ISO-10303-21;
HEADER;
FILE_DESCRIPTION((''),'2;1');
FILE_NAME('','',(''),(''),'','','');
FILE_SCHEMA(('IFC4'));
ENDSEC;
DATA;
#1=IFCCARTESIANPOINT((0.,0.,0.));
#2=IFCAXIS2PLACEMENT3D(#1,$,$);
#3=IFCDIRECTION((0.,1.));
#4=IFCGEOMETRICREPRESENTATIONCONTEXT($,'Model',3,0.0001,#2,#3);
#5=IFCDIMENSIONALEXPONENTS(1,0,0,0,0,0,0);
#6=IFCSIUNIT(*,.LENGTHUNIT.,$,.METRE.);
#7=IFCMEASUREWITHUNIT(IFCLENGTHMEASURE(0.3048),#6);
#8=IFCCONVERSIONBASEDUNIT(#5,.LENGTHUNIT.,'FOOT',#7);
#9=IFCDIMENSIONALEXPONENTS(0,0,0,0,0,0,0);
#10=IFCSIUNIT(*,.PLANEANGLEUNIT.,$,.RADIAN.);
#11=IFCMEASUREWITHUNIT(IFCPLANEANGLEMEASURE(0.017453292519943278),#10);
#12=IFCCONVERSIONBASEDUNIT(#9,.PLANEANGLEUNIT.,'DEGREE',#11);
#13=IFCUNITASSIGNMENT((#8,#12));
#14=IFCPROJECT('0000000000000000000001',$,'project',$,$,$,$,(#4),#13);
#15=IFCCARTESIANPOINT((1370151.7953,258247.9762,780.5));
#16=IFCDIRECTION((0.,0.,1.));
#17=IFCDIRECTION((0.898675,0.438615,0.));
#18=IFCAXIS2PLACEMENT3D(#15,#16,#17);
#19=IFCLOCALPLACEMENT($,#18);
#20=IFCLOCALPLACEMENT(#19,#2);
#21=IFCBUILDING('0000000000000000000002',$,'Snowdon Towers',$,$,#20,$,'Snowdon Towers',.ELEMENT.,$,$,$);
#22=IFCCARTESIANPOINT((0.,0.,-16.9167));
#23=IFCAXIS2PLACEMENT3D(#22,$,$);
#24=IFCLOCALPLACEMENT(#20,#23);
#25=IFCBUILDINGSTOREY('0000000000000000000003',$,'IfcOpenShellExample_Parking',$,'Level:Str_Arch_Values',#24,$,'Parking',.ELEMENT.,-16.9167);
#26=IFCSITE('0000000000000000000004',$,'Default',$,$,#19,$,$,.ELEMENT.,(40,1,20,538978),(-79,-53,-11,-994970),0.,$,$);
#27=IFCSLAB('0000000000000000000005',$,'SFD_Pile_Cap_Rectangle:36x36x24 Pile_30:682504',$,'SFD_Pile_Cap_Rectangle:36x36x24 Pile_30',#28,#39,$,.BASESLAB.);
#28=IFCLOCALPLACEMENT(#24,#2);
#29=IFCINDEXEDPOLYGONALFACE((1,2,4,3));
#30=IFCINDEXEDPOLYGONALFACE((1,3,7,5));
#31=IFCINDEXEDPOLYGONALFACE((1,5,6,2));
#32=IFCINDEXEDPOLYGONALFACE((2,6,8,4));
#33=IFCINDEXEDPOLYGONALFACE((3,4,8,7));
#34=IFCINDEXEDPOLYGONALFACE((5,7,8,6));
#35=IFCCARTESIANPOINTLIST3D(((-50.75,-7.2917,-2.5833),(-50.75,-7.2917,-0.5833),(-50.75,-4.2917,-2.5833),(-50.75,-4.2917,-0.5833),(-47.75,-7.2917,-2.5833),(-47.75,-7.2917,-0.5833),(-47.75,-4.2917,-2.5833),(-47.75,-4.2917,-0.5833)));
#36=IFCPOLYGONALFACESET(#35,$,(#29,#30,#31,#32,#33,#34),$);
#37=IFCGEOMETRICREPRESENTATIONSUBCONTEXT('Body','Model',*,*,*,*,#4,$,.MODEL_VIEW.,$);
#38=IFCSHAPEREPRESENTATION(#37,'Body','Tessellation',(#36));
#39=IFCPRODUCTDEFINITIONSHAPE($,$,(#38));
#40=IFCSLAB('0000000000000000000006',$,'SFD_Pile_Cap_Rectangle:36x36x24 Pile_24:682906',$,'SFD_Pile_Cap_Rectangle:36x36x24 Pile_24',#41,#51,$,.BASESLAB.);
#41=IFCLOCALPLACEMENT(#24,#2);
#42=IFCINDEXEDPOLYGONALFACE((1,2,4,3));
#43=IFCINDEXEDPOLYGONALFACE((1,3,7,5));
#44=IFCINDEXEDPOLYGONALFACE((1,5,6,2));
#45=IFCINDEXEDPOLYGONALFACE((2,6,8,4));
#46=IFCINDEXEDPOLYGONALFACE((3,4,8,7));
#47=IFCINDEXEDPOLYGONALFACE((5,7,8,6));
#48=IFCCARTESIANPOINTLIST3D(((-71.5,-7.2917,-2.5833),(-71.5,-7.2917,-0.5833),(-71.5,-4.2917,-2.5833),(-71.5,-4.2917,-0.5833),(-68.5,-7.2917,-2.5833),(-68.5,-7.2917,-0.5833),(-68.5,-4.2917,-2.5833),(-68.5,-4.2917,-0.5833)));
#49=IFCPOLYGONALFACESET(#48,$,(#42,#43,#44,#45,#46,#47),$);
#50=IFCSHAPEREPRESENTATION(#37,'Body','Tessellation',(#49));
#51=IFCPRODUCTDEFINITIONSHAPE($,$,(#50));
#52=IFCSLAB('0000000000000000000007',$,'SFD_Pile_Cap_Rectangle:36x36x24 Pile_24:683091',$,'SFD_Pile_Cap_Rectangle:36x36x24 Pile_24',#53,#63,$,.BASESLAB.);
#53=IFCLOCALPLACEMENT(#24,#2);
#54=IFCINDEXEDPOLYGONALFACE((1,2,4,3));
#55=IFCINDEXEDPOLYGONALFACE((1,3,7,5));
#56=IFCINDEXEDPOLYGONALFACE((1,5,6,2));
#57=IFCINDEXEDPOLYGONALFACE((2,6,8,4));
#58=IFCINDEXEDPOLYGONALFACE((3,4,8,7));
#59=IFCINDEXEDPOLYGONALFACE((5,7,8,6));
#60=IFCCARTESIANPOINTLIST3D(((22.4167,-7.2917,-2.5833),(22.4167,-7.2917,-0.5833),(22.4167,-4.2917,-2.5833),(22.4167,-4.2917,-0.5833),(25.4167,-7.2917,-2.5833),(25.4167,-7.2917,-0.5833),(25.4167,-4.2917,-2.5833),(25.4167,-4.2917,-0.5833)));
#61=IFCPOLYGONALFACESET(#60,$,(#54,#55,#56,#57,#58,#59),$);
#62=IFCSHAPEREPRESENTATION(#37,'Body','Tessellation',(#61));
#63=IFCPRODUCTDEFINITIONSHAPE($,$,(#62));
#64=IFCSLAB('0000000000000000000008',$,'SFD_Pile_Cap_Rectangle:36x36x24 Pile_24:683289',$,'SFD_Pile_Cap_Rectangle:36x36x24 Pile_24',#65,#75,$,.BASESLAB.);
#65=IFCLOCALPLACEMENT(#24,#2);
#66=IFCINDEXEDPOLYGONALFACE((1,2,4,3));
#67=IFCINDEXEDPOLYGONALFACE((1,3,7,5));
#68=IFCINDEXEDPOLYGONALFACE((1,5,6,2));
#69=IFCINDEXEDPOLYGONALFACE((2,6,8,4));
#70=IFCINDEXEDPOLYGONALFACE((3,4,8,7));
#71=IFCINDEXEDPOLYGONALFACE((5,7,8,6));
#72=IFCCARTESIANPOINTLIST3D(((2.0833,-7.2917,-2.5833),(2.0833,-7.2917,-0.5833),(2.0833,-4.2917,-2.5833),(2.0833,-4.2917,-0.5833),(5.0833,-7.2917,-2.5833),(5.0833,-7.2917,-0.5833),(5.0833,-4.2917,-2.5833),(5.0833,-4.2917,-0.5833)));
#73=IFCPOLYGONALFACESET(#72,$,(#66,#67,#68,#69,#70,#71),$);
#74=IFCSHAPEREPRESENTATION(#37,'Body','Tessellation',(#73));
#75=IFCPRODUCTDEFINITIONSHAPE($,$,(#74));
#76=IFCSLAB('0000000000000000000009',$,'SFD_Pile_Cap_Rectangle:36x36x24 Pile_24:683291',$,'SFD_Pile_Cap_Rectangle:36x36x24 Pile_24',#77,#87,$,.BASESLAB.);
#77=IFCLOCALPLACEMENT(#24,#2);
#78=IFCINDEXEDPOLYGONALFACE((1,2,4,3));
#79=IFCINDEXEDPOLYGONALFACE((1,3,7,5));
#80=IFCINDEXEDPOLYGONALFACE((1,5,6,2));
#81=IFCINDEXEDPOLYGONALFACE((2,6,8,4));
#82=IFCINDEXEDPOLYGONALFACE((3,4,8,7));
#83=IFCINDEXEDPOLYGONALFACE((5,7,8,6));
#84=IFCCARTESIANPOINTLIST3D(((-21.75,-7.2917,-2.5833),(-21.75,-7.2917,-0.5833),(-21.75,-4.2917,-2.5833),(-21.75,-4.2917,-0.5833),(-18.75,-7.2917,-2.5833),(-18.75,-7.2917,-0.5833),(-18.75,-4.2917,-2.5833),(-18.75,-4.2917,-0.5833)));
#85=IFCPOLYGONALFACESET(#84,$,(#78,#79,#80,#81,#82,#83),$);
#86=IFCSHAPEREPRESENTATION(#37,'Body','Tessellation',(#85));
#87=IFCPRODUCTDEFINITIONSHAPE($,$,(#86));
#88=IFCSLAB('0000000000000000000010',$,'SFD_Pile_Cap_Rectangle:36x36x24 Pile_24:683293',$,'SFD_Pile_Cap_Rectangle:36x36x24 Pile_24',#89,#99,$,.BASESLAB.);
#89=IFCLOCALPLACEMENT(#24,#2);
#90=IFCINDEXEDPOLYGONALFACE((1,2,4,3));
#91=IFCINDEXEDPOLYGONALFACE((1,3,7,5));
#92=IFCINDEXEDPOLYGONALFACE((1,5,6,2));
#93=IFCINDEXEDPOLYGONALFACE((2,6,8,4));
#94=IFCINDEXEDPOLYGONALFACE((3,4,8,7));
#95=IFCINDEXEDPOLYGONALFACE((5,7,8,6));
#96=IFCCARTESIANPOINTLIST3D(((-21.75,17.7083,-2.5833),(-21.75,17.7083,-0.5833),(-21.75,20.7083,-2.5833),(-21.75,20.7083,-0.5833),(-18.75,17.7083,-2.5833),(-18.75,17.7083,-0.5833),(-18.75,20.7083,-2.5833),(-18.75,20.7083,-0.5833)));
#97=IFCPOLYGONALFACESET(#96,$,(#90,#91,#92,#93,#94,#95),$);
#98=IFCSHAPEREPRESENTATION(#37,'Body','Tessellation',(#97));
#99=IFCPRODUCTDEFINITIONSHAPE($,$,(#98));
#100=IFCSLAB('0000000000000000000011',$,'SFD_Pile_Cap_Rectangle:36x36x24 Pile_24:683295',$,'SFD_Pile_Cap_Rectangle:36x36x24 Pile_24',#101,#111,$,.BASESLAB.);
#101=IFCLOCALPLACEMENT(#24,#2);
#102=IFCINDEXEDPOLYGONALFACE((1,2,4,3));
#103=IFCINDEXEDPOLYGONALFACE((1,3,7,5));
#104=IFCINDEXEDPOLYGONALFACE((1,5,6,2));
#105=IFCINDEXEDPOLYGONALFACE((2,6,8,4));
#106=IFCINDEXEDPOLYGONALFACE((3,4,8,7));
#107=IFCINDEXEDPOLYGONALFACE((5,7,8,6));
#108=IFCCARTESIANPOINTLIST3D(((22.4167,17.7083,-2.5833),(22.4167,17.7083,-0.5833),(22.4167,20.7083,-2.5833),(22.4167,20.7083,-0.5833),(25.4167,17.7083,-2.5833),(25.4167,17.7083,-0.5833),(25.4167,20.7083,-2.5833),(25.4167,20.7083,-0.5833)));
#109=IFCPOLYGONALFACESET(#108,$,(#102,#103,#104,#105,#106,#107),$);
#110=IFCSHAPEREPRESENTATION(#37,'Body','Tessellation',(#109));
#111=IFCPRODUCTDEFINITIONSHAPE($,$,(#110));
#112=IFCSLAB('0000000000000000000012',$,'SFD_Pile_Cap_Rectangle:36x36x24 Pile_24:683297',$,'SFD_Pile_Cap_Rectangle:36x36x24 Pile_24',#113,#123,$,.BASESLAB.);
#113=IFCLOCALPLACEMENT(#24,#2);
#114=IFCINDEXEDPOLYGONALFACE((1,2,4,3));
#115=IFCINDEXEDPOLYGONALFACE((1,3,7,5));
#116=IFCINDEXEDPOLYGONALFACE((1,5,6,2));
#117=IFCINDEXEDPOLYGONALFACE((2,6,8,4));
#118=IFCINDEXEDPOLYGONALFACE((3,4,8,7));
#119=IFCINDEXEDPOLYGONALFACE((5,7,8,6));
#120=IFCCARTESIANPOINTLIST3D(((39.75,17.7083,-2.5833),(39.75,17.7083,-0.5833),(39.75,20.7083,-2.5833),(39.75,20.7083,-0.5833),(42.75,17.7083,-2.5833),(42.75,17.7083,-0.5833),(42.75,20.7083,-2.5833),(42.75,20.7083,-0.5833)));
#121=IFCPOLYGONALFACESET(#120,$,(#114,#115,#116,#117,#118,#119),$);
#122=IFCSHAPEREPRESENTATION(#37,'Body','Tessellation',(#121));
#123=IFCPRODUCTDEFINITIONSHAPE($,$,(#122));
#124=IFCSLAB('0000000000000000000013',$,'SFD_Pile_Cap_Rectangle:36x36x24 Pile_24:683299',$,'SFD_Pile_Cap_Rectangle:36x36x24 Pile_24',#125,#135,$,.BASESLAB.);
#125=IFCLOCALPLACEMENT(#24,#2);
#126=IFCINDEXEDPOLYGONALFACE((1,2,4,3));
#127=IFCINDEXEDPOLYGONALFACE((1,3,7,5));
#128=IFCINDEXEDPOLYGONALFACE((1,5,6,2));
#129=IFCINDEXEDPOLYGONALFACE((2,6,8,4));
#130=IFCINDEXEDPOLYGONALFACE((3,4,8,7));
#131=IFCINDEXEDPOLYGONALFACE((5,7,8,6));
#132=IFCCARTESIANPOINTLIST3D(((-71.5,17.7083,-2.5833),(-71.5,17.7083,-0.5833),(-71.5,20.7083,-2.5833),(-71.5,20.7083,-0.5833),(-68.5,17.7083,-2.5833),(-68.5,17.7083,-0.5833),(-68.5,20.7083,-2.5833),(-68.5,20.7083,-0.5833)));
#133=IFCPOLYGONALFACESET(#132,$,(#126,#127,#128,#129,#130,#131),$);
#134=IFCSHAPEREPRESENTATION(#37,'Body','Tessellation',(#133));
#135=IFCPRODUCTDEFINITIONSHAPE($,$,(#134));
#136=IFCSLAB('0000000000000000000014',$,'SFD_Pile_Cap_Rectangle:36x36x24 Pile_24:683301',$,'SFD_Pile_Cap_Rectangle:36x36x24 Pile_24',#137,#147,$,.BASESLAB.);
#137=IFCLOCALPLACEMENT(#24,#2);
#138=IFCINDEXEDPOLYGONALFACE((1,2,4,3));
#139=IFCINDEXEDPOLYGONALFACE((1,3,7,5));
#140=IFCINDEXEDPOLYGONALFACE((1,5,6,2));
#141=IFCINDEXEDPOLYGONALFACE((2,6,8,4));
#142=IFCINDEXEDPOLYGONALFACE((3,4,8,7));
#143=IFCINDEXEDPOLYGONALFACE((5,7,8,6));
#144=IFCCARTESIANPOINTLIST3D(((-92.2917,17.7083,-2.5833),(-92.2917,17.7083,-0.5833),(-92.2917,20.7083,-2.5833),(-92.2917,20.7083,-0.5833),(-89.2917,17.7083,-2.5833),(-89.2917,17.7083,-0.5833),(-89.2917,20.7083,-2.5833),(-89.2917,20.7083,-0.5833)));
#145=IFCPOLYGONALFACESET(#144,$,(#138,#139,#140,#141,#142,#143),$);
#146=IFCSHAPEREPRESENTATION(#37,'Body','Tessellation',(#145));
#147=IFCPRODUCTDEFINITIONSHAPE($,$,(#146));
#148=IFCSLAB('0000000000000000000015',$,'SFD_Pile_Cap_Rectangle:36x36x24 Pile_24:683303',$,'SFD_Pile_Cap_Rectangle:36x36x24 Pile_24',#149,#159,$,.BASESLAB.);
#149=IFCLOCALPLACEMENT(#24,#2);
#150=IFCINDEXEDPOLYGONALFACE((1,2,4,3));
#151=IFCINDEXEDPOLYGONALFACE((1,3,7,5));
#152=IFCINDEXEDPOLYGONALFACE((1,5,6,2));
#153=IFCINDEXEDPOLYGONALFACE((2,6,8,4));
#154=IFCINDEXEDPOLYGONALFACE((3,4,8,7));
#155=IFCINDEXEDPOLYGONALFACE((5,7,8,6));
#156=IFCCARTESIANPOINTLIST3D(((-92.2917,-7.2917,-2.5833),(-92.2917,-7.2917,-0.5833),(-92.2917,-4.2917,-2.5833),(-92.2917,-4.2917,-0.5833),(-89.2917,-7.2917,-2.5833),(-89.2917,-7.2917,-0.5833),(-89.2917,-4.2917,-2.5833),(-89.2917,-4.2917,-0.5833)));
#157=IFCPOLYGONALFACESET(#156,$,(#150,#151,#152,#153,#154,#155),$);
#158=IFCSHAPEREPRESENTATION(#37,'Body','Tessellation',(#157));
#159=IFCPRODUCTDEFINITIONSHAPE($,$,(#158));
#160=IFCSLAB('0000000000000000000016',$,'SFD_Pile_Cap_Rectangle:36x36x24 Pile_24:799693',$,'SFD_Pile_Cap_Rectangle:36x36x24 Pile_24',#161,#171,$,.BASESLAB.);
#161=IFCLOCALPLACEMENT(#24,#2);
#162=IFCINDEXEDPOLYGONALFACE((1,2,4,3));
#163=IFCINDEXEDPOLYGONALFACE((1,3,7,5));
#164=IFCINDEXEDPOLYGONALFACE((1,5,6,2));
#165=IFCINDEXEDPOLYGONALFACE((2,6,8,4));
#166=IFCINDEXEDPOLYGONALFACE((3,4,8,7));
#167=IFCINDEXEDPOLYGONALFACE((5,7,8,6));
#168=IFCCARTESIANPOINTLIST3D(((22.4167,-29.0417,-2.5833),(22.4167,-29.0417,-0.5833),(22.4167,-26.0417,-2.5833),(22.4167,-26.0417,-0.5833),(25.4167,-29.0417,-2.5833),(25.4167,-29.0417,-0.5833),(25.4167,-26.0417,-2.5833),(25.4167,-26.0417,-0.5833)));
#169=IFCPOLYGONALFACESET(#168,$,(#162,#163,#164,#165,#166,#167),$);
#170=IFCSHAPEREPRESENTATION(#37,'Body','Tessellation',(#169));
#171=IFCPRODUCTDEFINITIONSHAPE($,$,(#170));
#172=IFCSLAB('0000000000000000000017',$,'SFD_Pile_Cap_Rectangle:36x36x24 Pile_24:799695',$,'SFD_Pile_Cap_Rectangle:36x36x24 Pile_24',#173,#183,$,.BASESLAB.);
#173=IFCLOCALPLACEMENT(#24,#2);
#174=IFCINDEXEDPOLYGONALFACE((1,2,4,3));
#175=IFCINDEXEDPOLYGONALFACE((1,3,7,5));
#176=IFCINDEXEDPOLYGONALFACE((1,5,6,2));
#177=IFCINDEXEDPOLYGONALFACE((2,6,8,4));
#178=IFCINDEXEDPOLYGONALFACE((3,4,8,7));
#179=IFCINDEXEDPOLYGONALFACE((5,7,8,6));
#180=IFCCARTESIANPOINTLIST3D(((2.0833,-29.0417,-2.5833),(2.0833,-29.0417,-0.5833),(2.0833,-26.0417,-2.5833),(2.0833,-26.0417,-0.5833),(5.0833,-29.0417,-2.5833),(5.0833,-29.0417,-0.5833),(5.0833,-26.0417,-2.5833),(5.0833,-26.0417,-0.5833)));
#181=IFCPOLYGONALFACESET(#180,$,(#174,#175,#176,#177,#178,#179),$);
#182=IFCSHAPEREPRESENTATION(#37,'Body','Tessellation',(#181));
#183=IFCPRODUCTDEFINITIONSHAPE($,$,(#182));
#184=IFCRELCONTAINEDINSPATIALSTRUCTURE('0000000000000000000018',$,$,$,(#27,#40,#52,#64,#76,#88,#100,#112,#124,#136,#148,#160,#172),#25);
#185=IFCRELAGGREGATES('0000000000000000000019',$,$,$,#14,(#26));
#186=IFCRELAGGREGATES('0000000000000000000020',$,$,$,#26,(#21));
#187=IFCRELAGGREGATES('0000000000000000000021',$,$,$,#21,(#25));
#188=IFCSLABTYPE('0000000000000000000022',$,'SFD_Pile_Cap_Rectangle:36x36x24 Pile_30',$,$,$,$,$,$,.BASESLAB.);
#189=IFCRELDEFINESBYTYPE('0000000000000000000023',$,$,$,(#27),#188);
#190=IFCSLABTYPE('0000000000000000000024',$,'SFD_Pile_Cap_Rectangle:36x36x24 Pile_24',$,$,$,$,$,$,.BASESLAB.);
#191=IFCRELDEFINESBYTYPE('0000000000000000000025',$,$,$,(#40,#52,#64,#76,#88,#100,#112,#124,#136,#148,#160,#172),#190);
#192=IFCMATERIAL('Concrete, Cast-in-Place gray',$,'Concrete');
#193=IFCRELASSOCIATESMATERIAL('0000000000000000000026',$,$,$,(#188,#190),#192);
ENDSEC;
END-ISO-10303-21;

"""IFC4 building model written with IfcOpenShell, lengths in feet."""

from ifc_helpers import new_model, entity, si_unit, converted_unit, direction, frame, origin, place, context, subcontext, project, spatial, indexed_curve, outline, extrude, material, type_object, element, save


model = new_model("IFC4")

# Units and contexts
model_context = context("Model", 3, precision=0.0001, world=origin(), true_north=direction((0.0, 1.0)))
body_context = subcontext(model_context, "Body", "Model", "MODEL_VIEW")
ifc_project = project(units=[converted_unit("LENGTHUNIT", "FOOT", entity("IfcLengthMeasure", 0.3048), si_unit("LENGTHUNIT", "METRE"), dimensions=[1, 0, 0, 0, 0, 0, 0]), converted_unit("PLANEANGLEUNIT", "DEGREE", entity("IfcPlaneAngleMeasure", 0.017453292519943278), si_unit("PLANEANGLEUNIT", "RADIAN"), dimensions=[0, 0, 0, 0, 0, 0, 0])], contexts=[model_context])

# Site, building, storey
site_placement = place(None, frame((1370151.7953, 258247.9762, 780.5), z_axis=(0.0, 0.0, 1.0), x_axis=(0.898675, 0.438615, 0.0)))
site = spatial("IfcSite", under=ifc_project, at=site_placement, Name="Default", CompositionType="ELEMENT", RefLatitude=(40, 1, 20, 538978), RefLongitude=(-79, -53, -11, -994970), RefElevation=0.0)
building_placement = place(site_placement, origin())
building = spatial("IfcBuilding", under=site, at=building_placement, Name="Snowdon Towers", LongName="Snowdon Towers", CompositionType="ELEMENT")
storey_placement = place(building_placement, frame((0.0, 0.0, -16.9167)))
storey = spatial("IfcBuildingStorey", under=building, at=storey_placement, Name="IfcOpenShellExample_Parking", ObjectType="Level:Str_Arch_Values", LongName="Parking", CompositionType="ELEMENT", Elevation=-16.9167)

# Slabs
ifc_material = material(Name="Concrete, Cast-in-Place gray", Category="Concrete")
slab_type_1 = type_object("IfcSlabType", Name="SFD_Pile_Cap_Rectangle:36x36x24 Pile_30", PredefinedType="BASESLAB", material=ifc_material)
slab_1_placement = place(storey_placement, origin())
element("IfcSlab", 1, at=slab_1_placement, inside=storey, type_object=slab_type_1, Name="SFD_Pile_Cap_Rectangle:36x36x24 Pile_30:682504", ObjectType="SFD_Pile_Cap_Rectangle:36x36x24 Pile_30", PredefinedType="BASESLAB", context=body_context, shape_type="SweptSolid", body=[
    extrude(outline(indexed_curve([(-1.5, -1.5), (1.5, -1.5), (1.5, 1.5), (-1.5, 1.5), (-1.5, -1.5)], self_intersect=False)), frame((-49.25, -5.7917, -2.5833), z_axis=(0.0, 0.0, 1.0), x_axis=(-1.0, 0.0, 0.0)), (0.0, 0.0, 1.0), 2.0),
])
slab_type_2 = type_object("IfcSlabType", Name="SFD_Pile_Cap_Rectangle:36x36x24 Pile_24", PredefinedType="BASESLAB", material=ifc_material)
slab_2_placement = place(storey_placement, origin())
element("IfcSlab", 2, at=slab_2_placement, inside=storey, type_object=slab_type_2, Name="SFD_Pile_Cap_Rectangle:36x36x24 Pile_24:682906", ObjectType="SFD_Pile_Cap_Rectangle:36x36x24 Pile_24", PredefinedType="BASESLAB", context=body_context, shape_type="SweptSolid", body=[
    extrude(outline(indexed_curve([(-1.5, -1.5), (1.5, -1.5), (1.5, 1.5), (-1.5, 1.5), (-1.5, -1.5)], self_intersect=False)), frame((-70.0, -5.7917, -2.5833), z_axis=(0.0, 0.0, 1.0), x_axis=(-1.0, 0.0, 0.0)), (0.0, 0.0, 1.0), 2.0),
])
slab_3_placement = place(storey_placement, origin())
element("IfcSlab", 3, at=slab_3_placement, inside=storey, type_object=slab_type_2, Name="SFD_Pile_Cap_Rectangle:36x36x24 Pile_24:683091", ObjectType="SFD_Pile_Cap_Rectangle:36x36x24 Pile_24", PredefinedType="BASESLAB", context=body_context, shape_type="SweptSolid", body=[
    extrude(outline(indexed_curve([(-1.5, -1.5), (1.5, -1.5), (1.5, 1.5), (-1.5, 1.5), (-1.5, -1.5)], self_intersect=False)), frame((23.9167, -5.7917, -2.5833), z_axis=(0.0, 0.0, 1.0), x_axis=(-1.0, 0.0, 0.0)), (0.0, 0.0, 1.0), 2.0),
])
slab_4_placement = place(storey_placement, origin())
element("IfcSlab", 4, at=slab_4_placement, inside=storey, type_object=slab_type_2, Name="SFD_Pile_Cap_Rectangle:36x36x24 Pile_24:683289", ObjectType="SFD_Pile_Cap_Rectangle:36x36x24 Pile_24", PredefinedType="BASESLAB", context=body_context, shape_type="SweptSolid", body=[
    extrude(outline(indexed_curve([(-1.5, -1.5), (1.5, -1.5), (1.5, 1.5), (-1.5, 1.5), (-1.5, -1.5)], self_intersect=False)), frame((3.5833, -5.7917, -2.5833), z_axis=(0.0, 0.0, 1.0), x_axis=(-1.0, 0.0, 0.0)), (0.0, 0.0, 1.0), 2.0),
])
slab_5_placement = place(storey_placement, origin())
element("IfcSlab", 5, at=slab_5_placement, inside=storey, type_object=slab_type_2, Name="SFD_Pile_Cap_Rectangle:36x36x24 Pile_24:683291", ObjectType="SFD_Pile_Cap_Rectangle:36x36x24 Pile_24", PredefinedType="BASESLAB", context=body_context, shape_type="SweptSolid", body=[
    extrude(outline(indexed_curve([(-1.5, -1.5), (1.5, -1.5), (1.5, 1.5), (-1.5, 1.5), (-1.5, -1.5)], self_intersect=False)), frame((-20.25, -5.7917, -2.5833), z_axis=(0.0, 0.0, 1.0), x_axis=(-1.0, 0.0, 0.0)), (0.0, 0.0, 1.0), 2.0),
])
slab_6_placement = place(storey_placement, origin())
element("IfcSlab", 6, at=slab_6_placement, inside=storey, type_object=slab_type_2, Name="SFD_Pile_Cap_Rectangle:36x36x24 Pile_24:683293", ObjectType="SFD_Pile_Cap_Rectangle:36x36x24 Pile_24", PredefinedType="BASESLAB", context=body_context, shape_type="SweptSolid", body=[
    extrude(outline(indexed_curve([(-1.5, -1.5), (1.5, -1.5), (1.5, 1.5), (-1.5, 1.5), (-1.5, -1.5)], self_intersect=False)), frame((-20.25, 19.2083, -2.5833), z_axis=(0.0, 0.0, 1.0), x_axis=(-1.0, 0.0, 0.0)), (0.0, 0.0, 1.0), 2.0),
])
slab_7_placement = place(storey_placement, origin())
element("IfcSlab", 7, at=slab_7_placement, inside=storey, type_object=slab_type_2, Name="SFD_Pile_Cap_Rectangle:36x36x24 Pile_24:683295", ObjectType="SFD_Pile_Cap_Rectangle:36x36x24 Pile_24", PredefinedType="BASESLAB", context=body_context, shape_type="SweptSolid", body=[
    extrude(outline(indexed_curve([(-1.5, -1.5), (1.5, -1.5), (1.5, 1.5), (-1.5, 1.5), (-1.5, -1.5)], self_intersect=False)), frame((23.9167, 19.2083, -2.5833), z_axis=(0.0, 0.0, 1.0), x_axis=(-1.0, 0.0, 0.0)), (0.0, 0.0, 1.0), 2.0),
])
slab_8_placement = place(storey_placement, origin())
element("IfcSlab", 8, at=slab_8_placement, inside=storey, type_object=slab_type_2, Name="SFD_Pile_Cap_Rectangle:36x36x24 Pile_24:683297", ObjectType="SFD_Pile_Cap_Rectangle:36x36x24 Pile_24", PredefinedType="BASESLAB", context=body_context, shape_type="SweptSolid", body=[
    extrude(outline(indexed_curve([(-1.5, -1.5), (1.5, -1.5), (1.5, 1.5), (-1.5, 1.5), (-1.5, -1.5)], self_intersect=False)), frame((41.25, 19.2083, -2.5833), z_axis=(0.0, 0.0, 1.0), x_axis=(-1.0, 0.0, 0.0)), (0.0, 0.0, 1.0), 2.0),
])
slab_9_placement = place(storey_placement, origin())
element("IfcSlab", 9, at=slab_9_placement, inside=storey, type_object=slab_type_2, Name="SFD_Pile_Cap_Rectangle:36x36x24 Pile_24:683299", ObjectType="SFD_Pile_Cap_Rectangle:36x36x24 Pile_24", PredefinedType="BASESLAB", context=body_context, shape_type="SweptSolid", body=[
    extrude(outline(indexed_curve([(-1.5, -1.5), (1.5, -1.5), (1.5, 1.5), (-1.5, 1.5), (-1.5, -1.5)], self_intersect=False)), frame((-70.0, 19.2083, -2.5833), z_axis=(0.0, 0.0, 1.0), x_axis=(-1.0, 0.0, 0.0)), (0.0, 0.0, 1.0), 2.0),
])
slab_10_placement = place(storey_placement, origin())
element("IfcSlab", 10, at=slab_10_placement, inside=storey, type_object=slab_type_2, Name="SFD_Pile_Cap_Rectangle:36x36x24 Pile_24:683301", ObjectType="SFD_Pile_Cap_Rectangle:36x36x24 Pile_24", PredefinedType="BASESLAB", context=body_context, shape_type="SweptSolid", body=[
    extrude(outline(indexed_curve([(-1.5, -1.5), (1.5, -1.5), (1.5, 1.5), (-1.5, 1.5), (-1.5, -1.5)], self_intersect=False)), frame((-90.7917, 19.2083, -2.5833), z_axis=(0.0, 0.0, 1.0), x_axis=(-1.0, 0.0, 0.0)), (0.0, 0.0, 1.0), 2.0),
])
slab_11_placement = place(storey_placement, origin())
element("IfcSlab", 11, at=slab_11_placement, inside=storey, type_object=slab_type_2, Name="SFD_Pile_Cap_Rectangle:36x36x24 Pile_24:683303", ObjectType="SFD_Pile_Cap_Rectangle:36x36x24 Pile_24", PredefinedType="BASESLAB", context=body_context, shape_type="SweptSolid", body=[
    extrude(outline(indexed_curve([(-1.5, -1.5), (1.5, -1.5), (1.5, 1.5), (-1.5, 1.5), (-1.5, -1.5)], self_intersect=False)), frame((-90.7917, -5.7917, -2.5833), z_axis=(0.0, 0.0, 1.0), x_axis=(-1.0, 0.0, 0.0)), (0.0, 0.0, 1.0), 2.0),
])
slab_12_placement = place(storey_placement, origin())
element("IfcSlab", 12, at=slab_12_placement, inside=storey, type_object=slab_type_2, Name="SFD_Pile_Cap_Rectangle:36x36x24 Pile_24:799693", ObjectType="SFD_Pile_Cap_Rectangle:36x36x24 Pile_24", PredefinedType="BASESLAB", context=body_context, shape_type="SweptSolid", body=[
    extrude(outline(indexed_curve([(-1.5, -1.5), (1.5, -1.5), (1.5, 1.5), (-1.5, 1.5), (-1.5, -1.5)], self_intersect=False)), frame((23.9167, -27.5417, -2.5833), z_axis=(0.0, 0.0, 1.0), x_axis=(-1.0, 0.0, 0.0)), (0.0, 0.0, 1.0), 2.0),
])
slab_13_placement = place(storey_placement, origin())
element("IfcSlab", 13, at=slab_13_placement, inside=storey, type_object=slab_type_2, Name="SFD_Pile_Cap_Rectangle:36x36x24 Pile_24:799695", ObjectType="SFD_Pile_Cap_Rectangle:36x36x24 Pile_24", PredefinedType="BASESLAB", context=body_context, shape_type="SweptSolid", body=[
    extrude(outline(indexed_curve([(-1.5, -1.5), (1.5, -1.5), (1.5, 1.5), (-1.5, 1.5), (-1.5, -1.5)], self_intersect=False)), frame((3.5833, -27.5417, -2.5833), z_axis=(0.0, 0.0, 1.0), x_axis=(-1.0, 0.0, 0.0)), (0.0, 0.0, 1.0), 2.0),
])

save(model, "model.ifc")
